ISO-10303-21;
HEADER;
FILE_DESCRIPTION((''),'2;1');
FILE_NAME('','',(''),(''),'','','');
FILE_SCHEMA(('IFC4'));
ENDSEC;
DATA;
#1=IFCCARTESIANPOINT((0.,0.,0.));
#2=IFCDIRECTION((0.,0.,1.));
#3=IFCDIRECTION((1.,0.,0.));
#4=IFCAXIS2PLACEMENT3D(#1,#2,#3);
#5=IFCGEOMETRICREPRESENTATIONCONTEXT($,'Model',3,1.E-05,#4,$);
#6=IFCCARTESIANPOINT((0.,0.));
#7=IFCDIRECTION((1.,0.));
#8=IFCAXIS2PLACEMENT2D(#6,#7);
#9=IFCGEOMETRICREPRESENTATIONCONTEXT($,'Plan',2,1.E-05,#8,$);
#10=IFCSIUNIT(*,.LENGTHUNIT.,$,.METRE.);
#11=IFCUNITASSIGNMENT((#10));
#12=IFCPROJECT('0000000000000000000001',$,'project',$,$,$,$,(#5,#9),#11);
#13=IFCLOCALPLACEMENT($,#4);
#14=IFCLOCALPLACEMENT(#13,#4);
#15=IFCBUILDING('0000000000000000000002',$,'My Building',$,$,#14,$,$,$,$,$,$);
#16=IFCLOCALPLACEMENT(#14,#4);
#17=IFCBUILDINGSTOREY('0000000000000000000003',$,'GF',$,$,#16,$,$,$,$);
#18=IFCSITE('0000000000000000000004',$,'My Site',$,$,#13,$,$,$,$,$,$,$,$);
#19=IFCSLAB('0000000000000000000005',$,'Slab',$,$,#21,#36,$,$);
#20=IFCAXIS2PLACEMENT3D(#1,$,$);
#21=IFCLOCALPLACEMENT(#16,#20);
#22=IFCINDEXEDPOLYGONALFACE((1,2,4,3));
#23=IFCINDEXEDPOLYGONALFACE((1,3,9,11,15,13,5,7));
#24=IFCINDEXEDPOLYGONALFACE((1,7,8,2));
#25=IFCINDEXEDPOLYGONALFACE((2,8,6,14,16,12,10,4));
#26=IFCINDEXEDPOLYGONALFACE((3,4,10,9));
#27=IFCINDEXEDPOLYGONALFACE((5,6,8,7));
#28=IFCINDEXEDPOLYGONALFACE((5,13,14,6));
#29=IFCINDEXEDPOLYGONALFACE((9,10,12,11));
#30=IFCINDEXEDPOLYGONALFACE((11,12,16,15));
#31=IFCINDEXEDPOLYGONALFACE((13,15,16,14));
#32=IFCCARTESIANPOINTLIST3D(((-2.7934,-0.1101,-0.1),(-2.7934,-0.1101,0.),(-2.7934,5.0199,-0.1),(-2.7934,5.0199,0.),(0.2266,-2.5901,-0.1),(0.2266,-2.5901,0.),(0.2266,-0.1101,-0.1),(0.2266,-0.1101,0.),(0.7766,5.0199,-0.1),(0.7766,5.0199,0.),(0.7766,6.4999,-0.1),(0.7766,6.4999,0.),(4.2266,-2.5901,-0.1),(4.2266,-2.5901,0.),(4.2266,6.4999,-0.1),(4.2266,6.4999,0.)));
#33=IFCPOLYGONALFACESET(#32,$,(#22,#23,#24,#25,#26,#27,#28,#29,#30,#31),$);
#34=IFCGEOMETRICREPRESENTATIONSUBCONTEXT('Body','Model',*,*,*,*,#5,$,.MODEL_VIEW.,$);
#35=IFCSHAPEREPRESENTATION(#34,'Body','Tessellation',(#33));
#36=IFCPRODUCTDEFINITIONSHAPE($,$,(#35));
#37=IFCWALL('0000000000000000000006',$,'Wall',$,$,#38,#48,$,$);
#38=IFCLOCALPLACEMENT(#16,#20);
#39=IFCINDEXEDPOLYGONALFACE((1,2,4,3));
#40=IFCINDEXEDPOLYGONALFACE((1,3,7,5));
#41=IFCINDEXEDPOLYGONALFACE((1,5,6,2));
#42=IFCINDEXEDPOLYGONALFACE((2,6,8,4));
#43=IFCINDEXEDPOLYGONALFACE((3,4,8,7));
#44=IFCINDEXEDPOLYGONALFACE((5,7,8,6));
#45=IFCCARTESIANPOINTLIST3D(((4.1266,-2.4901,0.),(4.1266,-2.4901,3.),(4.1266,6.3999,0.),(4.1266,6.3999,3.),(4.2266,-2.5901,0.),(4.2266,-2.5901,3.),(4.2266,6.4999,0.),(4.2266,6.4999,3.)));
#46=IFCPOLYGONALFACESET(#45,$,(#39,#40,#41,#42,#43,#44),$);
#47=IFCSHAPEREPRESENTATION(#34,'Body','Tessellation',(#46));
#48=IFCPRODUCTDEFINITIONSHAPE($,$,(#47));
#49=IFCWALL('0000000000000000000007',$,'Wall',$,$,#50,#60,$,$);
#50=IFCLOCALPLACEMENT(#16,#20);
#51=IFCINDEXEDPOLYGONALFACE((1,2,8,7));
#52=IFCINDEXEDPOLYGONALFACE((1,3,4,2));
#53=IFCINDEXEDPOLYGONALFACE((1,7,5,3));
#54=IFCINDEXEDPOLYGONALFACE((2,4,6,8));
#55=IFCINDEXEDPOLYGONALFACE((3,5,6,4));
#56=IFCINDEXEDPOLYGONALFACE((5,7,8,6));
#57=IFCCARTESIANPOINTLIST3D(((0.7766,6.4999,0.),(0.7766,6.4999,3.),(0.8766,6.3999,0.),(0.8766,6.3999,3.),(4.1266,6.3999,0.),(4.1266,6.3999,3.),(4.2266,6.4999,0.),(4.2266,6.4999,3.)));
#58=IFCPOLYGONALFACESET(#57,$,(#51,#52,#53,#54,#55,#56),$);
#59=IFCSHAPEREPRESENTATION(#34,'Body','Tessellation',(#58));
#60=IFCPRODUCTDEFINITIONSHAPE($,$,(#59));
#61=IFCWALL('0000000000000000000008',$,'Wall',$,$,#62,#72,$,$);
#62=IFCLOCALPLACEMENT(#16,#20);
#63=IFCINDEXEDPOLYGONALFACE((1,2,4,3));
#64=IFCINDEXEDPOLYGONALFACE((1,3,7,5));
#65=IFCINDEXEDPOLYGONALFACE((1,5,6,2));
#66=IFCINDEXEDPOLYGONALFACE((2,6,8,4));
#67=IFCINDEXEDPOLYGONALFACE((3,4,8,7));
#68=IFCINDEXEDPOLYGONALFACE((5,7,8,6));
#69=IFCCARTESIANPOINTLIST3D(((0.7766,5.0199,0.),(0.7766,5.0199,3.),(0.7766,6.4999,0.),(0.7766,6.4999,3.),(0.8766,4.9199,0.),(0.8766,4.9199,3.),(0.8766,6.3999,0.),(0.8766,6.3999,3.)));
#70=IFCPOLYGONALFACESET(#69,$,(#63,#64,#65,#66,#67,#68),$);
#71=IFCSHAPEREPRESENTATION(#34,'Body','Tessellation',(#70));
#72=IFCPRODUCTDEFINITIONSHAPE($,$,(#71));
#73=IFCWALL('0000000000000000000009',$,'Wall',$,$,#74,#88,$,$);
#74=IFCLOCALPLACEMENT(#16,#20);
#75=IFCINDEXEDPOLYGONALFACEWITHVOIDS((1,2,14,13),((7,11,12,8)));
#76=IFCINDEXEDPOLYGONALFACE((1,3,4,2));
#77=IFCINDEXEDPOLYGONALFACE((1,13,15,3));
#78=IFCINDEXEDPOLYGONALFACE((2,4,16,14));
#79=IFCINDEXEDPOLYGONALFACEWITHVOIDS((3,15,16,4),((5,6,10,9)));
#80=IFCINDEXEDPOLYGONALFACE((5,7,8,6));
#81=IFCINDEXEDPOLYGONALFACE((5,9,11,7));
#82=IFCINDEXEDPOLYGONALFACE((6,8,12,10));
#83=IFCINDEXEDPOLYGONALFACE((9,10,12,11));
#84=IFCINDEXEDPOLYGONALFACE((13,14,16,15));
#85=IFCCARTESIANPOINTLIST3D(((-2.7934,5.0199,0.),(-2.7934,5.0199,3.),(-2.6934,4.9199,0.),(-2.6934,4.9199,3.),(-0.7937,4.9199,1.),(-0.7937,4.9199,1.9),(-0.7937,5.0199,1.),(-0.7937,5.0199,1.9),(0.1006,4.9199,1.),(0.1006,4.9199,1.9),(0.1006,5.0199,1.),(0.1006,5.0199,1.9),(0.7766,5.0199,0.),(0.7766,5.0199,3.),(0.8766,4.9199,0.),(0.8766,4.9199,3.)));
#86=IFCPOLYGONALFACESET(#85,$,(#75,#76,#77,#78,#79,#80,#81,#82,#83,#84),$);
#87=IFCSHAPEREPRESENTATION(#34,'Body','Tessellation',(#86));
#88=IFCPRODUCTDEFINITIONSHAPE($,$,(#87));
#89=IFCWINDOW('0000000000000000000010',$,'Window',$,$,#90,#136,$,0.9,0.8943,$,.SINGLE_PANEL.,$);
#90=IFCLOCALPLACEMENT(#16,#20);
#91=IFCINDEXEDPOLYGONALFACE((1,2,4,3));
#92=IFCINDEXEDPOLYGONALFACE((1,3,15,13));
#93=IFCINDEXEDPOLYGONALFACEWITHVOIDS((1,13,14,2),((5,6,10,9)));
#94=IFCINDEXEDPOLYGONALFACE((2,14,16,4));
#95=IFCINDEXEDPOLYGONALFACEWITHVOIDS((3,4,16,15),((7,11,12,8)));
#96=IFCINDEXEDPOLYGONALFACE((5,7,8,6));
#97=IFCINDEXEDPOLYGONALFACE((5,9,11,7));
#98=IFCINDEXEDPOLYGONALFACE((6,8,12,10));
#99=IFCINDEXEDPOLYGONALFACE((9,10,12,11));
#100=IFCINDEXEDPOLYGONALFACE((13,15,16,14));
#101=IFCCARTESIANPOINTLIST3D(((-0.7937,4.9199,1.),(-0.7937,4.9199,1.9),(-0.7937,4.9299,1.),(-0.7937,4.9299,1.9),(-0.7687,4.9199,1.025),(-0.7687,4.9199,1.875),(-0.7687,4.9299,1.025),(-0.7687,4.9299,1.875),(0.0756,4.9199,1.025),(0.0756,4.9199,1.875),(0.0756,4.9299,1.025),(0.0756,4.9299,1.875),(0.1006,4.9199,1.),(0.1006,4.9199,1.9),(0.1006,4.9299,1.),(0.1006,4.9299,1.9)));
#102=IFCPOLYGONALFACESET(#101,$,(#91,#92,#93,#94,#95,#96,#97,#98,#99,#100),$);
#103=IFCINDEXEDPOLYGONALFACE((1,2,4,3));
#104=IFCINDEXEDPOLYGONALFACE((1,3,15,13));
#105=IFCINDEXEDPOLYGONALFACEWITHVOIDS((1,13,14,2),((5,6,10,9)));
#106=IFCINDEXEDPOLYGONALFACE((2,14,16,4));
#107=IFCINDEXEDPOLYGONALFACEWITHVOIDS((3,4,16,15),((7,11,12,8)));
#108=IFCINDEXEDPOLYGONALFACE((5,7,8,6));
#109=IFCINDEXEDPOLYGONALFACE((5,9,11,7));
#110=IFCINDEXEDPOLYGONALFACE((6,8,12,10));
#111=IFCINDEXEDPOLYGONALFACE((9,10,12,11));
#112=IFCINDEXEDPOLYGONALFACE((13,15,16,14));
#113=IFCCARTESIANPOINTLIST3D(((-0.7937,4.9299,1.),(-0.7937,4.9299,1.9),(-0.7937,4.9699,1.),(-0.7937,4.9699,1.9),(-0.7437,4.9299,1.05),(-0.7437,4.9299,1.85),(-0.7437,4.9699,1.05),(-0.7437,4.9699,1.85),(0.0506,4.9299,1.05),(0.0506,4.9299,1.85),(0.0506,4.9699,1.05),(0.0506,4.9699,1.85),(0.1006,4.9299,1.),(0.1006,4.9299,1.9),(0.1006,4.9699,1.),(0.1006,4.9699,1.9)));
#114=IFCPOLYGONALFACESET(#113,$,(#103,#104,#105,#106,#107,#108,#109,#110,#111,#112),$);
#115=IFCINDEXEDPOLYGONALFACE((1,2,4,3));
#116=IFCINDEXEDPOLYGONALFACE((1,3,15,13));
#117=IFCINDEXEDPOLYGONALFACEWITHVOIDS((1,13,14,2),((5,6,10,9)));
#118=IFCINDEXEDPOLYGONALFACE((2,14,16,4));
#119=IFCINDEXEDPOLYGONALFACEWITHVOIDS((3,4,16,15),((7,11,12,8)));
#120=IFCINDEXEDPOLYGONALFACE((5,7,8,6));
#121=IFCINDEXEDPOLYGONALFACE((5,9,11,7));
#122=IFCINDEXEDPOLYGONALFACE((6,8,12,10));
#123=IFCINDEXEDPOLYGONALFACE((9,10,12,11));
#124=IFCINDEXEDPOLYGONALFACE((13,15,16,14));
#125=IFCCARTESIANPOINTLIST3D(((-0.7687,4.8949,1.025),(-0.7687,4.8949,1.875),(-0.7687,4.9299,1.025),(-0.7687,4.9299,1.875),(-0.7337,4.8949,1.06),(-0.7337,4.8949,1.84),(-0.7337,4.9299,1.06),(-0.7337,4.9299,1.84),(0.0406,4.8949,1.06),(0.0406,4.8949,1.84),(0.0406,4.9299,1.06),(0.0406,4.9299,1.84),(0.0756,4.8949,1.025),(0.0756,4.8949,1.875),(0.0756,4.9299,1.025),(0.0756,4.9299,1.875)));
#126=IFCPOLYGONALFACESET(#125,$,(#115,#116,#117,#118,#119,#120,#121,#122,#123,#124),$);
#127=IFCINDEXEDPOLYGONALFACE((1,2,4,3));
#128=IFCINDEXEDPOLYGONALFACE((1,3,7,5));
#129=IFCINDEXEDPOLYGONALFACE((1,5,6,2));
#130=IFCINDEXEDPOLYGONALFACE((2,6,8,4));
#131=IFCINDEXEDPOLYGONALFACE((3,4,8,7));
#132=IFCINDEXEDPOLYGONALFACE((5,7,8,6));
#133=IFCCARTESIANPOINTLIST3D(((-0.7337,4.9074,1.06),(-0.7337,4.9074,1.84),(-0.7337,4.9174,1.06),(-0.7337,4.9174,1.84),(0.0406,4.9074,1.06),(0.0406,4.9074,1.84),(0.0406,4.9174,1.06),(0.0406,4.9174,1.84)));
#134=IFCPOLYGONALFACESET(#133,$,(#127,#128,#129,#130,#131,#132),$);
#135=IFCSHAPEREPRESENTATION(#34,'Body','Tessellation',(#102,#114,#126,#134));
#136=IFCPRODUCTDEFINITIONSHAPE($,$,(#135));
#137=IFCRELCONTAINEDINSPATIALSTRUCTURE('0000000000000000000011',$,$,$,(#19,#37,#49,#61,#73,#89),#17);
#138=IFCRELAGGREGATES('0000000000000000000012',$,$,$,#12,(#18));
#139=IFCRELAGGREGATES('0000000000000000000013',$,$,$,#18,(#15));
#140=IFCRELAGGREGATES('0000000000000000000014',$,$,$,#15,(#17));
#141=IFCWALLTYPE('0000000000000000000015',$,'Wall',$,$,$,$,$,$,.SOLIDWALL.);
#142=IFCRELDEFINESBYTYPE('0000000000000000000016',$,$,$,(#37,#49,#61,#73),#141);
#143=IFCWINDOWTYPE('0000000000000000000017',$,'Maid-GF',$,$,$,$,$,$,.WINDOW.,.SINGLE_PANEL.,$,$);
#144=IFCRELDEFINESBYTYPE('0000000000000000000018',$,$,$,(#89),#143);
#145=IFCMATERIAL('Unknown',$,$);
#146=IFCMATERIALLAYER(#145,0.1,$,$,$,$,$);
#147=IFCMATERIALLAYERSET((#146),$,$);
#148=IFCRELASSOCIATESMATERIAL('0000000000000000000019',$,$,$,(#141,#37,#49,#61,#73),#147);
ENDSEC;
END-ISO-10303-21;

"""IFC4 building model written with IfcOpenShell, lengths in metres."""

from ifc_helpers import new_model, entity, si_unit, frame, origin_with_axes, origin_2d_with_axis, place, context, subcontext, project, spatial, line, indexed_curve, outline, extrude, shape, source, transform, mapped, material, layer, layer_set, layer_usage, type_object, type_shapes, element, fill, save


model = new_model("IFC4")

# Units and contexts
model_context = context("Model", 3, precision=1e-05, world=origin_with_axes())
plan_context = context("Plan", 2, precision=1e-05, world=origin_2d_with_axis())
body_context_1 = subcontext(model_context, "Body", "Model", "MODEL_VIEW")
body_context_2 = subcontext(plan_context, "Body", "Plan", "PLAN_VIEW")
ifc_project = project(units=[si_unit("LENGTHUNIT", "METRE")], contexts=[model_context, plan_context])

# Site, building, storey
site_placement = place(None, origin_with_axes())
site = spatial("IfcSite", under=ifc_project, at=site_placement, Name="My Site")
building_placement = place(site_placement, origin_with_axes())
building = spatial("IfcBuilding", under=site, at=building_placement, Name="My Building")
storey_placement = place(building_placement, origin_with_axes())
storey = spatial("IfcBuildingStorey", under=building, at=storey_placement, Name="GF")

# Slab
slab_placement = place(storey_placement, frame((4.2266, -2.5901, 0.0), z_axis=(0.0, 0.0, 1.0), x_axis=(1.0, 0.0, 0.0)))
element("IfcSlab", 1, at=slab_placement, inside=storey, Name="Slab", context=body_context_1, shape_type="SweptSolid", body=[
    extrude(outline(indexed_curve([(0.0, 0.0), (0.0, 9.09), (-3.45, 9.09), (-3.45, 7.61), (-7.02, 7.61), (-7.02, 2.48), (-4.0, 2.48), (-4.0, 0.0), (0.0, 0.0)])), frame((0.0, 0.0, -0.1), z_axis=(0.0, 0.0, 1.0), x_axis=(1.0, 0.0, 0.0)), (0.0, 0.0, 1.0), 0.1),
])

# Shared definitions
ifc_material = material(Name="Unknown")
ifc_layer = layer(ifc_material, 0.1)
ifc_layer_set = layer_set([ifc_layer])
wall_type = type_object("IfcWallType", Name="Wall", PredefinedType="SOLIDWALL", material=ifc_layer_set)

# Walls
ifc_layer_usage_1 = layer_usage(ifc_layer_set, "AXIS2", "POSITIVE", 0.0)
wall_1_placement = place(storey_placement, frame((4.2266, -2.5901, 0.0), z_axis=(0.0, 0.0, 1.0), x_axis=(0.0, 1.0, 0.0)))
element("IfcWall", 2, at=wall_1_placement, inside=storey, type_object=wall_type, material=ifc_layer_usage_1, Name="Wall", context=body_context_1, shape_type="SweptSolid", body=[
    extrude(outline(indexed_curve([(0.0, 0.0), (0.1, 0.1), (8.99, 0.1), (9.09, 0.0)], segments=[line(1, 2, 3, 4, 1)])), origin_with_axes(), (0.0, 0.0, 1.0), 3.0),
])
ifc_layer_usage_2 = layer_usage(ifc_layer_set, "AXIS2", "POSITIVE", 0.0)
wall_2_placement = place(storey_placement, frame((4.2266, 6.4999, 0.0), z_axis=(0.0, 0.0, 1.0), x_axis=(-1.0, 0.0, 0.0)))
element("IfcWall", 3, at=wall_2_placement, inside=storey, type_object=wall_type, material=ifc_layer_usage_2, Name="Wall", context=body_context_1, shape_type="SweptSolid", body=[
    extrude(outline(indexed_curve([(0.0, 0.0), (0.1, 0.1), (3.35, 0.1), (3.45, 0.0)], segments=[line(1, 2, 3, 4, 1)])), origin_with_axes(), (0.0, 0.0, 1.0), 3.0),
])
ifc_layer_usage_3 = layer_usage(ifc_layer_set, "AXIS2", "POSITIVE", 0.0)
wall_3_placement = place(storey_placement, frame((0.7766, 6.4999, 0.0), z_axis=(0.0, 0.0, 1.0), x_axis=(0.0, -1.0, 0.0)))
element("IfcWall", 4, at=wall_3_placement, inside=storey, type_object=wall_type, material=ifc_layer_usage_3, Name="Wall", context=body_context_1, shape_type="SweptSolid", body=[
    extrude(outline(indexed_curve([(0.0, 0.0), (0.1, 0.1), (1.58, 0.1), (1.48, 0.0)], segments=[line(1, 2, 3, 4, 1)])), origin_with_axes(), (0.0, 0.0, 1.0), 3.0),
])

# Wall, opening, window
ifc_layer_usage_4 = layer_usage(ifc_layer_set, "AXIS2", "POSITIVE", 0.0)
wall_4_placement = place(storey_placement, frame((0.7766, 5.0199, 0.0), z_axis=(0.0, 0.0, 1.0), x_axis=(-1.0, 0.0, 0.0)))
wall_4 = element("IfcWall", 5, at=wall_4_placement, inside=storey, type_object=wall_type, material=ifc_layer_usage_4, Name="Wall", context=body_context_1, shape_type="SweptSolid", body=[
    extrude(outline(indexed_curve([(0.0, 0.0), (-0.1, 0.1), (3.47, 0.1), (3.57, 0.0)], segments=[line(1, 2, 3, 4, 1)])), origin_with_axes(), (0.0, 0.0, 1.0), 3.0),
])
shared_shape_1 = source(origin_with_axes(), body_context_1, "Body", "SweptSolid", [
    extrude(outline(indexed_curve([(0.0, 0.0), (0.8943, 0.0), (0.8943, 0.9), (0.0, 0.9)], segments=[line(1, 2, 3, 4, 1)])), frame((0.0, -0.6, 0.0), z_axis=(0.0, -1.0, 0.0), x_axis=(1.0, 0.0, 0.0)), (0.0, 0.0, -1.0), 1.2),
])
opening_1_placement = place(wall_4_placement, frame((0.676, 0.0, 1.0), z_axis=(0.0, 0.0, 1.0), x_axis=(1.0, 0.0, 0.0)))
opening_1 = element("IfcOpeningElement", 6, at=opening_1_placement, cuts=wall_4, PredefinedType="OPENING", context=body_context_1, shape_type="MappedRepresentation", body=[
    mapped(shared_shape_1, transform((0.0, 0.0, 0.0), x_axis=(1.0, 0.0, 0.0), y_axis=(0.0, 1.0, 0.0), z_axis=(0.0, 0.0, 1.0), scale=1.0)),
])
window_type_1 = type_object("IfcWindowType", Name="Maid-GF", PartitioningType="SINGLE_PANEL", PredefinedType="WINDOW")
shared_shape_2 = source(origin_with_axes(), body_context_1, "Body", "SweptSolid", [
    extrude(outline(indexed_curve([(0.0, 0.0), (0.8943, 0.0), (0.8943, 0.9), (0.0, 0.9)], segments=[line(1, 2, 3, 4, 1)]), holes=[indexed_curve([(0.025, 0.025), (0.8693, 0.025), (0.8693, 0.875), (0.025, 0.875)], segments=[line(1, 2, 3, 4, 1)])]), frame((0.0, 0.09, 0.0), z_axis=(0.0, -1.0, 0.0), x_axis=(1.0, 0.0, 0.0)), (0.0, 0.0, -1.0), 0.01),
    extrude(outline(indexed_curve([(0.0, 0.0), (0.8943, 0.0), (0.8943, 0.9), (0.0, 0.9)], segments=[line(1, 2, 3, 4, 1)]), holes=[indexed_curve([(0.05, 0.05), (0.8443, 0.05), (0.8443, 0.85), (0.05, 0.85)], segments=[line(1, 2, 3, 4, 1)])]), frame((0.0, 0.05, 0.0), z_axis=(0.0, -1.0, 0.0), x_axis=(1.0, 0.0, 0.0)), (0.0, 0.0, -1.0), 0.04),
    extrude(outline(indexed_curve([(0.0, 0.0), (0.8443, 0.0), (0.8443, 0.85), (0.0, 0.85)], segments=[line(1, 2, 3, 4, 1)]), holes=[indexed_curve([(0.035, 0.035), (0.8093, 0.035), (0.8093, 0.815), (0.035, 0.815)], segments=[line(1, 2, 3, 4, 1)])]), frame((0.025, 0.09, 0.025), z_axis=(0.0, -1.0, 0.0), x_axis=(1.0, 0.0, 0.0)), (0.0, 0.0, -1.0), 0.035),
    extrude(outline(indexed_curve([(0.035, 0.035), (0.8093, 0.035), (0.8093, 0.815), (0.035, 0.815)], segments=[line(1, 2, 3, 4, 1)])), frame((0.025, 0.1025, 0.025), z_axis=(0.0, -1.0, 0.0), x_axis=(1.0, 0.0, 0.0)), (0.0, 0.0, -1.0), 0.01),
])
shared_shape_3 = source(origin_with_axes(), body_context_2, "Body", "Curve2D", [
    entity("IfcIndexedPolyCurve", entity("IfcCartesianPointList2D", [[0.05, 0.05], [0.8443, 0.05]])),
    entity("IfcIndexedPolyCurve", entity("IfcCartesianPointList2D", [[0.0, 0.1], [0.025, 0.1], [0.025, 0.09], [0.05, 0.09], [0.05, 0.05], [0.0, 0.05]]), [entity("IfcLineIndex", [1, 2, 3, 4, 5, 6, 1])]),
    entity("IfcIndexedPolyCurve", entity("IfcCartesianPointList2D", [[0.8943, 0.1], [0.8693, 0.1], [0.8693, 0.09], [0.8443, 0.09], [0.8443, 0.05], [0.8943, 0.05]]), [entity("IfcLineIndex", [1, 2, 3, 4, 5, 6, 1])]),
    entity("IfcIndexedPolyCurve", entity("IfcCartesianPointList2D", [[0.025, 0.09], [0.06, 0.09], [0.06, 0.125], [0.025, 0.125]]), [entity("IfcLineIndex", [1, 2, 3, 4, 1])]),
    entity("IfcIndexedPolyCurve", entity("IfcCartesianPointList2D", [[0.8693, 0.09], [0.8343, 0.09], [0.8343, 0.125], [0.8693, 0.125]]), [entity("IfcLineIndex", [1, 2, 3, 4, 1])]),
    entity("IfcIndexedPolyCurve", entity("IfcCartesianPointList2D", [[0.06, 0.09], [0.8343, 0.09]])),
    entity("IfcIndexedPolyCurve", entity("IfcCartesianPointList2D", [[0.06, 0.125], [0.8343, 0.125]])),
    entity("IfcIndexedPolyCurve", entity("IfcCartesianPointList2D", [[0.06, 0.1075], [0.8343, 0.1075]])),
])
type_shapes(window_type_1, [shared_shape_2, shared_shape_3])
window_1_placement = place(opening_1_placement, frame((0.0, 0.0, 0.0), z_axis=(0.0, 0.0, 1.0), x_axis=(1.0, 0.0, 0.0)))
window_1 = element("IfcWindow", 7, at=window_1_placement, inside=storey, type_object=window_type_1, Name="Window", OverallHeight=0.9, OverallWidth=0.8943, PartitioningType="SINGLE_PANEL", shapes=[
    shape(body_context_1, "Body", "MappedRepresentation", [mapped(shared_shape_2, transform((0.0, 0.0, 0.0), x_axis=(1.0, 0.0, 0.0), y_axis=(0.0, 1.0, 0.0), z_axis=(0.0, 0.0, 1.0), scale=1.0))]),
    shape(body_context_2, "Body", "MappedRepresentation", [mapped(shared_shape_3, transform((0.0, 0.0, 0.0), x_axis=(1.0, 0.0, 0.0), y_axis=(0.0, 1.0, 0.0), z_axis=(0.0, 0.0, 1.0), scale=1.0))]),
])
fill(opening_1, window_1)

save(model, "model.ifc")
